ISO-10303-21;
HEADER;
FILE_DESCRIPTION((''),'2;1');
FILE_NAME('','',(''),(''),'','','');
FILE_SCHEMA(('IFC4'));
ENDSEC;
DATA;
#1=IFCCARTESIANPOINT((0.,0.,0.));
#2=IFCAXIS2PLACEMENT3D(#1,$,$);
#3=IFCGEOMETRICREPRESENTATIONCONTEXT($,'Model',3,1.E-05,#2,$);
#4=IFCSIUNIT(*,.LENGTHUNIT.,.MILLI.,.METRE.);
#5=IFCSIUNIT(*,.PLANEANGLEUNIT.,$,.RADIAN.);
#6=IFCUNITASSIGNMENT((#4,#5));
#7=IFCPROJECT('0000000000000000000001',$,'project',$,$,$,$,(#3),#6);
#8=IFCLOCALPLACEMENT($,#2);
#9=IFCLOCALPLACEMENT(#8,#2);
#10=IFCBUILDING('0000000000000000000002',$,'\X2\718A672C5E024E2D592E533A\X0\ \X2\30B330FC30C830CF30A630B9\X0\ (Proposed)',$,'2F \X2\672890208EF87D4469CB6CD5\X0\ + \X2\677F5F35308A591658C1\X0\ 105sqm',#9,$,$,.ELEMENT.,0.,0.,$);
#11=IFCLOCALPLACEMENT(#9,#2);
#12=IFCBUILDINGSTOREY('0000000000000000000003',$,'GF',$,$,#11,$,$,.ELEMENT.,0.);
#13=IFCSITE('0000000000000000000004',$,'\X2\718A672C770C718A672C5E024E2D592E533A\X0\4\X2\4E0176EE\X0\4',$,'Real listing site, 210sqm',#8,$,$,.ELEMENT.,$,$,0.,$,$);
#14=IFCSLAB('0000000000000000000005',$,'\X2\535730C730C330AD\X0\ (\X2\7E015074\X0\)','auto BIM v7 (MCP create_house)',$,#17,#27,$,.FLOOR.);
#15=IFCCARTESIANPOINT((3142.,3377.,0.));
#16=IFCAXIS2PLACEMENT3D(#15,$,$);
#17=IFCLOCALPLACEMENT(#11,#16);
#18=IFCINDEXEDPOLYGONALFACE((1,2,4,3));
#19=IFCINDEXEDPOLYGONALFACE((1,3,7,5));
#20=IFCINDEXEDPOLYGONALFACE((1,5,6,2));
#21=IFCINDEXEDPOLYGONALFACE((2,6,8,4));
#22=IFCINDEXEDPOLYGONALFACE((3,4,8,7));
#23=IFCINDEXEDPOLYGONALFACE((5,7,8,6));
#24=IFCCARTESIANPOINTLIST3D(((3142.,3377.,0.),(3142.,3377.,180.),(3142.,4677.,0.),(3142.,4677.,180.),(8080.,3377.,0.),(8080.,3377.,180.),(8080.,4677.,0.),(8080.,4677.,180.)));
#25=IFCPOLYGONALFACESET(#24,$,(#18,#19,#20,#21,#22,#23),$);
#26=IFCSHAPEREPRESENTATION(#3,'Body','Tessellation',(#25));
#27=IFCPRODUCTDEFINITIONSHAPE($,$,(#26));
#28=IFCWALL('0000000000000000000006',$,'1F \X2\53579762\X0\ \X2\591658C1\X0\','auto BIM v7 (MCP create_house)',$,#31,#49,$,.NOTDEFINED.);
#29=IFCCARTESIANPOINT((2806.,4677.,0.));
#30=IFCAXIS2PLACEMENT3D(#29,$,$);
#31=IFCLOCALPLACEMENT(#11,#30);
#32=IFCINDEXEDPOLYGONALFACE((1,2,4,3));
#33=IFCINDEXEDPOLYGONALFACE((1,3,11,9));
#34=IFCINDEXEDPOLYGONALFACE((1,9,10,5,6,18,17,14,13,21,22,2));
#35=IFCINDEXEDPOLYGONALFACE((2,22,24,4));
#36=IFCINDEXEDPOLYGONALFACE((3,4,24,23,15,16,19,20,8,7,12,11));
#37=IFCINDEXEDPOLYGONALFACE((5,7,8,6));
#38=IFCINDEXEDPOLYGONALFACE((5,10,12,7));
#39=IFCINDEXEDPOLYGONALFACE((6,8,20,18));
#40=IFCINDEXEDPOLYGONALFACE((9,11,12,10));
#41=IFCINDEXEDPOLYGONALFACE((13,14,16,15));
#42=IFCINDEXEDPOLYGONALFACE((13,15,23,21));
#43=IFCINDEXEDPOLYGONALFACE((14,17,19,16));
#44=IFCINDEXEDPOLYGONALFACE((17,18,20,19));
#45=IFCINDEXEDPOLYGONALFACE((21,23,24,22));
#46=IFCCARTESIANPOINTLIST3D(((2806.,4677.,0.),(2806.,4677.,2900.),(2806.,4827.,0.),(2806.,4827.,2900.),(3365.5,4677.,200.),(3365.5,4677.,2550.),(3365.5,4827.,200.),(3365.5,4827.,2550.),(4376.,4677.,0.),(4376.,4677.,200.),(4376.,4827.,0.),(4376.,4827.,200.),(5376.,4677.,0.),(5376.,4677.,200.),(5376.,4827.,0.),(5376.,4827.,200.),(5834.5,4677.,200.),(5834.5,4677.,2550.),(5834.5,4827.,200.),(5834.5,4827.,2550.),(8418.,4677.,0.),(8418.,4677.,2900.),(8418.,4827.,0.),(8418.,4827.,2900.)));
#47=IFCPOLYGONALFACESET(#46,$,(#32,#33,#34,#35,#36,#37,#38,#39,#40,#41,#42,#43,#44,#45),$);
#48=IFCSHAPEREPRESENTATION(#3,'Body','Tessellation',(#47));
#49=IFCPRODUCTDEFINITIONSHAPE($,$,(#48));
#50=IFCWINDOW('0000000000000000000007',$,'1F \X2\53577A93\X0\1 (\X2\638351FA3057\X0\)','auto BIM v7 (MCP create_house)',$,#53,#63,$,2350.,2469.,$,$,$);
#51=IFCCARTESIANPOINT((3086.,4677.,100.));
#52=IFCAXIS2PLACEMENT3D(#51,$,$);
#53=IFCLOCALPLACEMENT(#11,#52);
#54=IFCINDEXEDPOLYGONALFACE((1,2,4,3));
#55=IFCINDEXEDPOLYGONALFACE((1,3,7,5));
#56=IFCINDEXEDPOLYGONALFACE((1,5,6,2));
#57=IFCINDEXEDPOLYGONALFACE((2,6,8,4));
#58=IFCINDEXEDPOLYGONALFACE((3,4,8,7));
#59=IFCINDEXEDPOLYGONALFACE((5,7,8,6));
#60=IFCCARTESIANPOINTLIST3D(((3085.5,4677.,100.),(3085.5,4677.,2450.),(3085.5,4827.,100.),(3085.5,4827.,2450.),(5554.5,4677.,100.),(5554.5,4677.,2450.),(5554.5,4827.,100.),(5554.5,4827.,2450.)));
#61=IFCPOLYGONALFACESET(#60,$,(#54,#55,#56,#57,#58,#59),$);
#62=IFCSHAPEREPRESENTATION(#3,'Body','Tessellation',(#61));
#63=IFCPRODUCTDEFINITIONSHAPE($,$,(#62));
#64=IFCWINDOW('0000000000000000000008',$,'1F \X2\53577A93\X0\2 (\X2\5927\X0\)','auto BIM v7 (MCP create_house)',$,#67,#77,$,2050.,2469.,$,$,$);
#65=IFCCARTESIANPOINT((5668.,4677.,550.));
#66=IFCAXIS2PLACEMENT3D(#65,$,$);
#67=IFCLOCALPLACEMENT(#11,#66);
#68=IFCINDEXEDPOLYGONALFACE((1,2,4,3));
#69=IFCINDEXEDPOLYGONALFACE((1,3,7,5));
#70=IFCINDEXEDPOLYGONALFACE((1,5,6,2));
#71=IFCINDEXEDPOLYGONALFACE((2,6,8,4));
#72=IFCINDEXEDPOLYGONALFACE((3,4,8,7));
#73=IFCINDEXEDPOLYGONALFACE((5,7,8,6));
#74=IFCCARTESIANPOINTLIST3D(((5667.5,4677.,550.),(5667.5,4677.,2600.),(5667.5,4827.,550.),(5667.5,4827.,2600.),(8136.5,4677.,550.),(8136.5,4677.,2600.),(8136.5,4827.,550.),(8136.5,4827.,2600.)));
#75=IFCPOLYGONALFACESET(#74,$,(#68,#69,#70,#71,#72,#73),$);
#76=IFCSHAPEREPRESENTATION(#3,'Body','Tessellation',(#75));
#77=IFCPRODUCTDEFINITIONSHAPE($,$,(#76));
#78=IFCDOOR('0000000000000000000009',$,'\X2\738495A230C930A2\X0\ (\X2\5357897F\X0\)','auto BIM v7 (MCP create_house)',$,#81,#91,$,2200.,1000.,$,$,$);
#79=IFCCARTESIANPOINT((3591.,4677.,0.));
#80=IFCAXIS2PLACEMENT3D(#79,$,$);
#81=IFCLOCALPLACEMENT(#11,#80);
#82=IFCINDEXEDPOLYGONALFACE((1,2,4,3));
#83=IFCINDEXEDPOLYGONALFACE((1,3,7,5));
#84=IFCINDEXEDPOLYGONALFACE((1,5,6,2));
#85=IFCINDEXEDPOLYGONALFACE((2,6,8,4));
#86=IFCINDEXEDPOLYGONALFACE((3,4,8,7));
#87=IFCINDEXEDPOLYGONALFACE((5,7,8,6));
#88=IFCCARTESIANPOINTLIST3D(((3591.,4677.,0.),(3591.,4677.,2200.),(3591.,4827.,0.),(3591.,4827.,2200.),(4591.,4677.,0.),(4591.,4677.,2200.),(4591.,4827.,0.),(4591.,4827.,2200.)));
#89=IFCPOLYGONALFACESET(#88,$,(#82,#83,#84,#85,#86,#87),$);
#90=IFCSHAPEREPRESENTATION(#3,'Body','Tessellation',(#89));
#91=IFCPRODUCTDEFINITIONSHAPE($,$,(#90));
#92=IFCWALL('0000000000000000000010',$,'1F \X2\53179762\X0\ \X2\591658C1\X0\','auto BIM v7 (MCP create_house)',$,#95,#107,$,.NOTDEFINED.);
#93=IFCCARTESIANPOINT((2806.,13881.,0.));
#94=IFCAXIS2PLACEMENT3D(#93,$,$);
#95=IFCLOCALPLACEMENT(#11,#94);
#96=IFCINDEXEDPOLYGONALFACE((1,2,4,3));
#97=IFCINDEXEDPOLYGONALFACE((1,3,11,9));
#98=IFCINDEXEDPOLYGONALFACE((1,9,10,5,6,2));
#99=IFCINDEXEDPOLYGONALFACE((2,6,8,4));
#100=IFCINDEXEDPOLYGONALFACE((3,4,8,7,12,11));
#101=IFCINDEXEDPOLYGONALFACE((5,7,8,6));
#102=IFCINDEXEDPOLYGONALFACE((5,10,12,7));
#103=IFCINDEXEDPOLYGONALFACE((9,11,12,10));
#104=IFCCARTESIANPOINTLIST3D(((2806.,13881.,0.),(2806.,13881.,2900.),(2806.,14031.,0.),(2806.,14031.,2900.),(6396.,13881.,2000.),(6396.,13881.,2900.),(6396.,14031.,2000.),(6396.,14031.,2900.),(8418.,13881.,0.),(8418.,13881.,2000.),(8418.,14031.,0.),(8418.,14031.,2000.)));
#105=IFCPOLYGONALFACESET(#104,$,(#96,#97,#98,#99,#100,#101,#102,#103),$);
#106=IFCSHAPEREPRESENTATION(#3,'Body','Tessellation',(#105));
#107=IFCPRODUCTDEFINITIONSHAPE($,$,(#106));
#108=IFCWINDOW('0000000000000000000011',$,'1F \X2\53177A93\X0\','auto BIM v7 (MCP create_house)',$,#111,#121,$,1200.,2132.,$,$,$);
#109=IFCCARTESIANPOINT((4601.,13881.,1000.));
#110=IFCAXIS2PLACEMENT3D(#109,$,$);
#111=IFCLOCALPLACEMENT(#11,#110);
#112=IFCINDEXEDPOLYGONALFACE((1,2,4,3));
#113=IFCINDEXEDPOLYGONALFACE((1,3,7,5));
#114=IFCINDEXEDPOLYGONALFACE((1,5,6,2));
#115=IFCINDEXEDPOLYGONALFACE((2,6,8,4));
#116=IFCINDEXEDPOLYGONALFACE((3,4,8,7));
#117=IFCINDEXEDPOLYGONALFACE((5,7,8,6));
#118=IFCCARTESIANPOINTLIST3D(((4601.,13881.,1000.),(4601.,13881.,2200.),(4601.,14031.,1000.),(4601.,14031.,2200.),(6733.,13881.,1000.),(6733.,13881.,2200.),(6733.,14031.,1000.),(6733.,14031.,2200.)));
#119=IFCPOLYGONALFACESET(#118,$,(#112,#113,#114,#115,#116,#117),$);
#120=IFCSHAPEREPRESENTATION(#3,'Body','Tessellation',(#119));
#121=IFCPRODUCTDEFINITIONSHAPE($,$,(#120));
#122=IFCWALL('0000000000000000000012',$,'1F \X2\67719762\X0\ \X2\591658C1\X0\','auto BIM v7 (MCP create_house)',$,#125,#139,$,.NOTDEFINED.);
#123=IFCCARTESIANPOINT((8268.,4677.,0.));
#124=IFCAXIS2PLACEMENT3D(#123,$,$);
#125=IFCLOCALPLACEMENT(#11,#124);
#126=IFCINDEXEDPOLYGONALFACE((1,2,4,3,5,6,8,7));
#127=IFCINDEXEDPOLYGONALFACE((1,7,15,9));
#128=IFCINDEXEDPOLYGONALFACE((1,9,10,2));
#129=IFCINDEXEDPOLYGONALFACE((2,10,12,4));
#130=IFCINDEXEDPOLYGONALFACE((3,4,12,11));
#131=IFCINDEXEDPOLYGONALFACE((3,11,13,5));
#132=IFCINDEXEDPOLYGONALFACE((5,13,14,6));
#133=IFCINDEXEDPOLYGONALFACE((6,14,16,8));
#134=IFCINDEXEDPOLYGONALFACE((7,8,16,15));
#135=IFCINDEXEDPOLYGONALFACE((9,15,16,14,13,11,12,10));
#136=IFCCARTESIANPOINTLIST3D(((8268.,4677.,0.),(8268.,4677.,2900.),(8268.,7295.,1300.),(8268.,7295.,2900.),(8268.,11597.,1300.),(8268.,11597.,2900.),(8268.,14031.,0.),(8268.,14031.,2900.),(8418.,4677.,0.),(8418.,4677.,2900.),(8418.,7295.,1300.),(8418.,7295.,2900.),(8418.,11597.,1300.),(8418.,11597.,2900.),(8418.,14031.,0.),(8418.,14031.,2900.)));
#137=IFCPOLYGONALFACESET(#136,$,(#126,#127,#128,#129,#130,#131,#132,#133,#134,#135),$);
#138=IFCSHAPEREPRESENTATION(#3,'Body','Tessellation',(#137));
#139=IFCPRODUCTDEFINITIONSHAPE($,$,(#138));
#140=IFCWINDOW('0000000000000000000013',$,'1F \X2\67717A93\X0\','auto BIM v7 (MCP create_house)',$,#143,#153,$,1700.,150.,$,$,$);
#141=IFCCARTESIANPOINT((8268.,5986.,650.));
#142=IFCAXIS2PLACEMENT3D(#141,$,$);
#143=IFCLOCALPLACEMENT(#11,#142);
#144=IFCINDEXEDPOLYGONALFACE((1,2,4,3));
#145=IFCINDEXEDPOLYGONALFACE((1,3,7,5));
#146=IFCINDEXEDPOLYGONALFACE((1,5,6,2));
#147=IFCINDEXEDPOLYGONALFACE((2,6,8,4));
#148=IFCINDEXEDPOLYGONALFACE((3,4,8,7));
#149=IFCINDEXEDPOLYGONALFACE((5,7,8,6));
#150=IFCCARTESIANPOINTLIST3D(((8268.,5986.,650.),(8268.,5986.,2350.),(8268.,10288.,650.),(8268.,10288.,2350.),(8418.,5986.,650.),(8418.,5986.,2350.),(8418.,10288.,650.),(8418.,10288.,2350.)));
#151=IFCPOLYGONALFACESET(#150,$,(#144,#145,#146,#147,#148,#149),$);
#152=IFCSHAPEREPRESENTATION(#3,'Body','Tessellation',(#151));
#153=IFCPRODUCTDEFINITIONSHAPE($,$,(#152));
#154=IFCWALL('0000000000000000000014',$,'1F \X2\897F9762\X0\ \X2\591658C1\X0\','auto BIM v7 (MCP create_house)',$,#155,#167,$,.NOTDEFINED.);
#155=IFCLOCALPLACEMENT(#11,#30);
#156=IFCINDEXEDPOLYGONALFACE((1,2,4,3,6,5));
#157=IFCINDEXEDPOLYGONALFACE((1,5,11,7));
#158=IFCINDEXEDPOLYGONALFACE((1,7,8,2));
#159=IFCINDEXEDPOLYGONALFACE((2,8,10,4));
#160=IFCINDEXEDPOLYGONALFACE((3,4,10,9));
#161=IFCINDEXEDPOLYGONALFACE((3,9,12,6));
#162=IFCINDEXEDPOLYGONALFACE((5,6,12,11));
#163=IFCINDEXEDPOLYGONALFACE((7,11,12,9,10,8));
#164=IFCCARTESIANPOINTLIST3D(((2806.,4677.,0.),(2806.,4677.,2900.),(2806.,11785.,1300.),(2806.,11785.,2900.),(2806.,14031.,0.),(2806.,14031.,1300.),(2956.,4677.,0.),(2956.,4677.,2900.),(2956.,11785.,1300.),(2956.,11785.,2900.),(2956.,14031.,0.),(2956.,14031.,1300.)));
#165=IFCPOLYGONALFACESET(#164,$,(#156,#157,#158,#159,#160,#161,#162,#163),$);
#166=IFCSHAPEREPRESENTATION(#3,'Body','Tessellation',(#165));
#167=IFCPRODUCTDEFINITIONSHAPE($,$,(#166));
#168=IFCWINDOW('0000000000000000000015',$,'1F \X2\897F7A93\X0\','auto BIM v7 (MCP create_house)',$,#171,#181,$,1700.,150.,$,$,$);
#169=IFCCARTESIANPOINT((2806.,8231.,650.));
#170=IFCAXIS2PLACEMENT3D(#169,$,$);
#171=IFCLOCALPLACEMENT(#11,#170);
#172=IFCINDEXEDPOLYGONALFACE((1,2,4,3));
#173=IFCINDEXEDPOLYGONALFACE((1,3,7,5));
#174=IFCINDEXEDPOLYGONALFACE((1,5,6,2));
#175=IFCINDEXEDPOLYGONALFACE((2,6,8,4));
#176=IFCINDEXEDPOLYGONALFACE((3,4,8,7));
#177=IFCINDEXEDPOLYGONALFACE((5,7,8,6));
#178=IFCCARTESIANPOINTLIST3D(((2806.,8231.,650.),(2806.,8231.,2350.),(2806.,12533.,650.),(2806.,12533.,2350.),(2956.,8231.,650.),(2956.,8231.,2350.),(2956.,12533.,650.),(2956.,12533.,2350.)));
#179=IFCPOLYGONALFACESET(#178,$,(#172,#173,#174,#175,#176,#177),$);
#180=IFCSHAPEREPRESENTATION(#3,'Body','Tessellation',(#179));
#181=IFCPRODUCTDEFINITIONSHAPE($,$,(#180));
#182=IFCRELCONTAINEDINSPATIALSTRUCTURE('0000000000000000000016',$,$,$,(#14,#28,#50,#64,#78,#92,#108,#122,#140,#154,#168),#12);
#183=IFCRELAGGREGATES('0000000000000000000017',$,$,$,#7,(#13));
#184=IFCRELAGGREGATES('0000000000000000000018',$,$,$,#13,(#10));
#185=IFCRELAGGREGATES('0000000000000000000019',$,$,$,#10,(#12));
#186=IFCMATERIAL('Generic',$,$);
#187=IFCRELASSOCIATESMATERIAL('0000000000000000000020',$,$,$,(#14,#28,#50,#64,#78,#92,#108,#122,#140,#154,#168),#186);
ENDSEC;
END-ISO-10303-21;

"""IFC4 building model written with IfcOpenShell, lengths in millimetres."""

from ifc_helpers import new_model, si_unit, frame, frame_2d, origin, place, context, project, spatial, rectangle, extrude, material, element, fill, save


model = new_model("IFC4")

# Units and contexts
model_context = context("Model", 3, precision=1e-05, world=origin())
ifc_project = project(units=[si_unit("LENGTHUNIT", "METRE", prefix="MILLI"), si_unit("PLANEANGLEUNIT", "RADIAN")], contexts=[model_context])

# Site, building, storey
site_placement = place(None, origin())
site = spatial("IfcSite", under=ifc_project, at=site_placement, Name="熊本県熊本市中央区4丁目4", ObjectType="Real listing site, 210sqm", CompositionType="ELEMENT", RefElevation=0.0)
building_placement = place(site_placement, origin())
building = spatial("IfcBuilding", under=site, at=building_placement, Name="熊本市中央区 コートハウス (Proposed)", ObjectType="2F 木造軸組構法 + 板張り外壁 105sqm", CompositionType="ELEMENT", ElevationOfRefHeight=0.0, ElevationOfTerrain=0.0)
storey_placement = place(building_placement, origin())
storey = spatial("IfcBuildingStorey", under=building, at=storey_placement, Name="GF", CompositionType="ELEMENT", Elevation=0.0)

# Slab
ifc_material = material(Name="Generic")
slab_1_placement = place(storey_placement, frame((3142.0, 3377.0, 0.0)))
element("IfcSlab", 1, at=slab_1_placement, inside=storey, material=ifc_material, Name="南デッキ (縁側)", Description="auto BIM v7 (MCP create_house)", PredefinedType="FLOOR", context=model_context, shape_type="SweptSolid", body=[
    extrude(rectangle(XDim=4938.0, YDim=1300.0, at=frame_2d((2469.0, 650.0))), frame((3142.0, 3377.0, 0.0)), (0.0, 0.0, 1.0), 180.0),
])

# Wall, openings, windows, door
wall_1_placement = place(storey_placement, frame((2806.0, 4677.0, 0.0)))
wall_1 = element("IfcWall", 2, at=wall_1_placement, inside=storey, material=ifc_material, Name="1F 南面 外壁", Description="auto BIM v7 (MCP create_house)", PredefinedType="NOTDEFINED", context=model_context, shape_type="SweptSolid", body=[
    extrude(rectangle(XDim=5612.0, YDim=150.0, at=frame_2d((2806.0, 75.0))), frame((2806.0, 4677.0, 0.0)), (0.0, 0.0, 1.0), 2900.0),
])
opening_1_placement = place(storey_placement, frame((3086.0, 4677.0, 100.0)))
opening_1 = element("IfcOpeningElement", 3, at=opening_1_placement, cuts=wall_1, PredefinedType="NOTDEFINED", context=model_context, shape_type="SweptSolid", body=[
    extrude(rectangle(XDim=2469.0, YDim=150.0, at=frame_2d((1234.0, 75.0))), frame((3086.0, 4677.0, 100.0)), (0.0, 0.0, 1.0), 2350.0),
])
opening_2_placement = place(storey_placement, frame((5668.0, 4677.0, 550.0)))
opening_2 = element("IfcOpeningElement", 4, at=opening_2_placement, cuts=wall_1, PredefinedType="NOTDEFINED", context=model_context, shape_type="SweptSolid", body=[
    extrude(rectangle(XDim=2469.0, YDim=150.0, at=frame_2d((1234.0, 75.0))), frame((5668.0, 4677.0, 550.0)), (0.0, 0.0, 1.0), 2050.0),
])
opening_3_placement = place(storey_placement, frame((3591.0, 4677.0, 0.0)))
opening_3 = element("IfcOpeningElement", 5, at=opening_3_placement, cuts=wall_1, PredefinedType="NOTDEFINED", context=model_context, shape_type="SweptSolid", body=[
    extrude(rectangle(XDim=1000.0, YDim=150.0, at=frame_2d((500.0, 75.0))), frame((3591.0, 4677.0, 0.0)), (0.0, 0.0, 1.0), 2200.0),
])
window_1_placement = place(storey_placement, frame((3086.0, 4677.0, 100.0)))
window_1 = element("IfcWindow", 6, at=window_1_placement, inside=storey, material=ifc_material, Name="1F 南窓1 (掃出し)", Description="auto BIM v7 (MCP create_house)", OverallHeight=2350.0, OverallWidth=2469.0, context=model_context, shape_type="SweptSolid", body=[
    extrude(rectangle(XDim=2469.0, YDim=150.0, at=frame_2d((1234.0, 75.0))), frame((3086.0, 4677.0, 100.0)), (0.0, 0.0, 1.0), 2350.0),
])
fill(opening_1, window_1)
window_2_placement = place(storey_placement, frame((5668.0, 4677.0, 550.0)))
window_2 = element("IfcWindow", 7, at=window_2_placement, inside=storey, material=ifc_material, Name="1F 南窓2 (大)", Description="auto BIM v7 (MCP create_house)", OverallHeight=2050.0, OverallWidth=2469.0, context=model_context, shape_type="SweptSolid", body=[
    extrude(rectangle(XDim=2469.0, YDim=150.0, at=frame_2d((1234.0, 75.0))), frame((5668.0, 4677.0, 550.0)), (0.0, 0.0, 1.0), 2050.0),
])
fill(opening_2, window_2)
door_placement = place(storey_placement, frame((3591.0, 4677.0, 0.0)))
door = element("IfcDoor", 8, at=door_placement, inside=storey, material=ifc_material, Name="玄関ドア (南西)", Description="auto BIM v7 (MCP create_house)", OverallHeight=2200.0, OverallWidth=1000.0, context=model_context, shape_type="SweptSolid", body=[
    extrude(rectangle(XDim=1000.0, YDim=150.0, at=frame_2d((500.0, 75.0))), frame((3591.0, 4677.0, 0.0)), (0.0, 0.0, 1.0), 2200.0),
])
fill(opening_3, door)

# Walls, openings, windows
wall_2_placement = place(storey_placement, frame((2806.0, 13881.0, 0.0)))
wall_2 = element("IfcWall", 9, at=wall_2_placement, inside=storey, material=ifc_material, Name="1F 北面 外壁", Description="auto BIM v7 (MCP create_house)", PredefinedType="NOTDEFINED", context=model_context, shape_type="SweptSolid", body=[
    extrude(rectangle(XDim=5612.0, YDim=150.0, at=frame_2d((2806.0, 75.0))), frame((2806.0, 13881.0, 0.0)), (0.0, 0.0, 1.0), 2900.0),
])
opening_4_placement = place(storey_placement, frame((4601.0, 13881.0, 1000.0)))
opening_4 = element("IfcOpeningElement", 10, at=opening_4_placement, cuts=wall_2, PredefinedType="NOTDEFINED", context=model_context, shape_type="SweptSolid", body=[
    extrude(rectangle(XDim=2132.0, YDim=150.0, at=frame_2d((1066.0, 75.0))), frame((4601.0, 13881.0, 1000.0)), (0.0, 0.0, 1.0), 1200.0),
])
window_3_placement = place(storey_placement, frame((4601.0, 13881.0, 1000.0)))
window_3 = element("IfcWindow", 11, at=window_3_placement, inside=storey, material=ifc_material, Name="1F 北窓", Description="auto BIM v7 (MCP create_house)", OverallHeight=1200.0, OverallWidth=2132.0, context=model_context, shape_type="SweptSolid", body=[
    extrude(rectangle(XDim=2132.0, YDim=150.0, at=frame_2d((1066.0, 75.0))), frame((4601.0, 13881.0, 1000.0)), (0.0, 0.0, 1.0), 1200.0),
])
fill(opening_4, window_3)
wall_3_placement = place(storey_placement, frame((8268.0, 4677.0, 0.0)))
wall_3 = element("IfcWall", 12, at=wall_3_placement, inside=storey, material=ifc_material, Name="1F 東面 外壁", Description="auto BIM v7 (MCP create_house)", PredefinedType="NOTDEFINED", context=model_context, shape_type="SweptSolid", body=[
    extrude(rectangle(XDim=150.0, YDim=9354.0, at=frame_2d((75.0, 4677.0))), frame((8268.0, 4677.0, 0.0)), (0.0, 0.0, 1.0), 2900.0),
])
opening_5_placement = place(storey_placement, frame((8268.0, 5986.0, 650.0)))
opening_5 = element("IfcOpeningElement", 13, at=opening_5_placement, cuts=wall_3, PredefinedType="NOTDEFINED", context=model_context, shape_type="SweptSolid", body=[
    extrude(rectangle(XDim=150.0, YDim=4302.0, at=frame_2d((75.0, 2151.0))), frame((8268.0, 5986.0, 650.0)), (0.0, 0.0, 1.0), 1700.0),
])
window_4_placement = place(storey_placement, frame((8268.0, 5986.0, 650.0)))
window_4 = element("IfcWindow", 14, at=window_4_placement, inside=storey, material=ifc_material, Name="1F 東窓", Description="auto BIM v7 (MCP create_house)", OverallHeight=1700.0, OverallWidth=150.0, context=model_context, shape_type="SweptSolid", body=[
    extrude(rectangle(XDim=150.0, YDim=4302.0, at=frame_2d((75.0, 2151.0))), frame((8268.0, 5986.0, 650.0)), (0.0, 0.0, 1.0), 1700.0),
])
fill(opening_5, window_4)
wall_4_placement = place(storey_placement, frame((2806.0, 4677.0, 0.0)))
wall_4 = element("IfcWall", 15, at=wall_4_placement, inside=storey, material=ifc_material, Name="1F 西面 外壁", Description="auto BIM v7 (MCP create_house)", PredefinedType="NOTDEFINED", context=model_context, shape_type="SweptSolid", body=[
    extrude(rectangle(XDim=150.0, YDim=9354.0, at=frame_2d((75.0, 4677.0))), frame((2806.0, 4677.0, 0.0)), (0.0, 0.0, 1.0), 2900.0),
])
opening_6_placement = place(storey_placement, frame((2806.0, 8231.0, 650.0)))
opening_6 = element("IfcOpeningElement", 16, at=opening_6_placement, cuts=wall_4, PredefinedType="NOTDEFINED", context=model_context, shape_type="SweptSolid", body=[
    extrude(rectangle(XDim=150.0, YDim=4302.0, at=frame_2d((75.0, 2151.0))), frame((2806.0, 8231.0, 650.0)), (0.0, 0.0, 1.0), 1700.0),
])
window_5_placement = place(storey_placement, frame((2806.0, 8231.0, 650.0)))
window_5 = element("IfcWindow", 17, at=window_5_placement, inside=storey, material=ifc_material, Name="1F 西窓", Description="auto BIM v7 (MCP create_house)", OverallHeight=1700.0, OverallWidth=150.0, context=model_context, shape_type="SweptSolid", body=[
    extrude(rectangle(XDim=150.0, YDim=4302.0, at=frame_2d((75.0, 2151.0))), frame((2806.0, 8231.0, 650.0)), (0.0, 0.0, 1.0), 1700.0),
])
fill(opening_6, window_5)

save(model, "model.ifc")
